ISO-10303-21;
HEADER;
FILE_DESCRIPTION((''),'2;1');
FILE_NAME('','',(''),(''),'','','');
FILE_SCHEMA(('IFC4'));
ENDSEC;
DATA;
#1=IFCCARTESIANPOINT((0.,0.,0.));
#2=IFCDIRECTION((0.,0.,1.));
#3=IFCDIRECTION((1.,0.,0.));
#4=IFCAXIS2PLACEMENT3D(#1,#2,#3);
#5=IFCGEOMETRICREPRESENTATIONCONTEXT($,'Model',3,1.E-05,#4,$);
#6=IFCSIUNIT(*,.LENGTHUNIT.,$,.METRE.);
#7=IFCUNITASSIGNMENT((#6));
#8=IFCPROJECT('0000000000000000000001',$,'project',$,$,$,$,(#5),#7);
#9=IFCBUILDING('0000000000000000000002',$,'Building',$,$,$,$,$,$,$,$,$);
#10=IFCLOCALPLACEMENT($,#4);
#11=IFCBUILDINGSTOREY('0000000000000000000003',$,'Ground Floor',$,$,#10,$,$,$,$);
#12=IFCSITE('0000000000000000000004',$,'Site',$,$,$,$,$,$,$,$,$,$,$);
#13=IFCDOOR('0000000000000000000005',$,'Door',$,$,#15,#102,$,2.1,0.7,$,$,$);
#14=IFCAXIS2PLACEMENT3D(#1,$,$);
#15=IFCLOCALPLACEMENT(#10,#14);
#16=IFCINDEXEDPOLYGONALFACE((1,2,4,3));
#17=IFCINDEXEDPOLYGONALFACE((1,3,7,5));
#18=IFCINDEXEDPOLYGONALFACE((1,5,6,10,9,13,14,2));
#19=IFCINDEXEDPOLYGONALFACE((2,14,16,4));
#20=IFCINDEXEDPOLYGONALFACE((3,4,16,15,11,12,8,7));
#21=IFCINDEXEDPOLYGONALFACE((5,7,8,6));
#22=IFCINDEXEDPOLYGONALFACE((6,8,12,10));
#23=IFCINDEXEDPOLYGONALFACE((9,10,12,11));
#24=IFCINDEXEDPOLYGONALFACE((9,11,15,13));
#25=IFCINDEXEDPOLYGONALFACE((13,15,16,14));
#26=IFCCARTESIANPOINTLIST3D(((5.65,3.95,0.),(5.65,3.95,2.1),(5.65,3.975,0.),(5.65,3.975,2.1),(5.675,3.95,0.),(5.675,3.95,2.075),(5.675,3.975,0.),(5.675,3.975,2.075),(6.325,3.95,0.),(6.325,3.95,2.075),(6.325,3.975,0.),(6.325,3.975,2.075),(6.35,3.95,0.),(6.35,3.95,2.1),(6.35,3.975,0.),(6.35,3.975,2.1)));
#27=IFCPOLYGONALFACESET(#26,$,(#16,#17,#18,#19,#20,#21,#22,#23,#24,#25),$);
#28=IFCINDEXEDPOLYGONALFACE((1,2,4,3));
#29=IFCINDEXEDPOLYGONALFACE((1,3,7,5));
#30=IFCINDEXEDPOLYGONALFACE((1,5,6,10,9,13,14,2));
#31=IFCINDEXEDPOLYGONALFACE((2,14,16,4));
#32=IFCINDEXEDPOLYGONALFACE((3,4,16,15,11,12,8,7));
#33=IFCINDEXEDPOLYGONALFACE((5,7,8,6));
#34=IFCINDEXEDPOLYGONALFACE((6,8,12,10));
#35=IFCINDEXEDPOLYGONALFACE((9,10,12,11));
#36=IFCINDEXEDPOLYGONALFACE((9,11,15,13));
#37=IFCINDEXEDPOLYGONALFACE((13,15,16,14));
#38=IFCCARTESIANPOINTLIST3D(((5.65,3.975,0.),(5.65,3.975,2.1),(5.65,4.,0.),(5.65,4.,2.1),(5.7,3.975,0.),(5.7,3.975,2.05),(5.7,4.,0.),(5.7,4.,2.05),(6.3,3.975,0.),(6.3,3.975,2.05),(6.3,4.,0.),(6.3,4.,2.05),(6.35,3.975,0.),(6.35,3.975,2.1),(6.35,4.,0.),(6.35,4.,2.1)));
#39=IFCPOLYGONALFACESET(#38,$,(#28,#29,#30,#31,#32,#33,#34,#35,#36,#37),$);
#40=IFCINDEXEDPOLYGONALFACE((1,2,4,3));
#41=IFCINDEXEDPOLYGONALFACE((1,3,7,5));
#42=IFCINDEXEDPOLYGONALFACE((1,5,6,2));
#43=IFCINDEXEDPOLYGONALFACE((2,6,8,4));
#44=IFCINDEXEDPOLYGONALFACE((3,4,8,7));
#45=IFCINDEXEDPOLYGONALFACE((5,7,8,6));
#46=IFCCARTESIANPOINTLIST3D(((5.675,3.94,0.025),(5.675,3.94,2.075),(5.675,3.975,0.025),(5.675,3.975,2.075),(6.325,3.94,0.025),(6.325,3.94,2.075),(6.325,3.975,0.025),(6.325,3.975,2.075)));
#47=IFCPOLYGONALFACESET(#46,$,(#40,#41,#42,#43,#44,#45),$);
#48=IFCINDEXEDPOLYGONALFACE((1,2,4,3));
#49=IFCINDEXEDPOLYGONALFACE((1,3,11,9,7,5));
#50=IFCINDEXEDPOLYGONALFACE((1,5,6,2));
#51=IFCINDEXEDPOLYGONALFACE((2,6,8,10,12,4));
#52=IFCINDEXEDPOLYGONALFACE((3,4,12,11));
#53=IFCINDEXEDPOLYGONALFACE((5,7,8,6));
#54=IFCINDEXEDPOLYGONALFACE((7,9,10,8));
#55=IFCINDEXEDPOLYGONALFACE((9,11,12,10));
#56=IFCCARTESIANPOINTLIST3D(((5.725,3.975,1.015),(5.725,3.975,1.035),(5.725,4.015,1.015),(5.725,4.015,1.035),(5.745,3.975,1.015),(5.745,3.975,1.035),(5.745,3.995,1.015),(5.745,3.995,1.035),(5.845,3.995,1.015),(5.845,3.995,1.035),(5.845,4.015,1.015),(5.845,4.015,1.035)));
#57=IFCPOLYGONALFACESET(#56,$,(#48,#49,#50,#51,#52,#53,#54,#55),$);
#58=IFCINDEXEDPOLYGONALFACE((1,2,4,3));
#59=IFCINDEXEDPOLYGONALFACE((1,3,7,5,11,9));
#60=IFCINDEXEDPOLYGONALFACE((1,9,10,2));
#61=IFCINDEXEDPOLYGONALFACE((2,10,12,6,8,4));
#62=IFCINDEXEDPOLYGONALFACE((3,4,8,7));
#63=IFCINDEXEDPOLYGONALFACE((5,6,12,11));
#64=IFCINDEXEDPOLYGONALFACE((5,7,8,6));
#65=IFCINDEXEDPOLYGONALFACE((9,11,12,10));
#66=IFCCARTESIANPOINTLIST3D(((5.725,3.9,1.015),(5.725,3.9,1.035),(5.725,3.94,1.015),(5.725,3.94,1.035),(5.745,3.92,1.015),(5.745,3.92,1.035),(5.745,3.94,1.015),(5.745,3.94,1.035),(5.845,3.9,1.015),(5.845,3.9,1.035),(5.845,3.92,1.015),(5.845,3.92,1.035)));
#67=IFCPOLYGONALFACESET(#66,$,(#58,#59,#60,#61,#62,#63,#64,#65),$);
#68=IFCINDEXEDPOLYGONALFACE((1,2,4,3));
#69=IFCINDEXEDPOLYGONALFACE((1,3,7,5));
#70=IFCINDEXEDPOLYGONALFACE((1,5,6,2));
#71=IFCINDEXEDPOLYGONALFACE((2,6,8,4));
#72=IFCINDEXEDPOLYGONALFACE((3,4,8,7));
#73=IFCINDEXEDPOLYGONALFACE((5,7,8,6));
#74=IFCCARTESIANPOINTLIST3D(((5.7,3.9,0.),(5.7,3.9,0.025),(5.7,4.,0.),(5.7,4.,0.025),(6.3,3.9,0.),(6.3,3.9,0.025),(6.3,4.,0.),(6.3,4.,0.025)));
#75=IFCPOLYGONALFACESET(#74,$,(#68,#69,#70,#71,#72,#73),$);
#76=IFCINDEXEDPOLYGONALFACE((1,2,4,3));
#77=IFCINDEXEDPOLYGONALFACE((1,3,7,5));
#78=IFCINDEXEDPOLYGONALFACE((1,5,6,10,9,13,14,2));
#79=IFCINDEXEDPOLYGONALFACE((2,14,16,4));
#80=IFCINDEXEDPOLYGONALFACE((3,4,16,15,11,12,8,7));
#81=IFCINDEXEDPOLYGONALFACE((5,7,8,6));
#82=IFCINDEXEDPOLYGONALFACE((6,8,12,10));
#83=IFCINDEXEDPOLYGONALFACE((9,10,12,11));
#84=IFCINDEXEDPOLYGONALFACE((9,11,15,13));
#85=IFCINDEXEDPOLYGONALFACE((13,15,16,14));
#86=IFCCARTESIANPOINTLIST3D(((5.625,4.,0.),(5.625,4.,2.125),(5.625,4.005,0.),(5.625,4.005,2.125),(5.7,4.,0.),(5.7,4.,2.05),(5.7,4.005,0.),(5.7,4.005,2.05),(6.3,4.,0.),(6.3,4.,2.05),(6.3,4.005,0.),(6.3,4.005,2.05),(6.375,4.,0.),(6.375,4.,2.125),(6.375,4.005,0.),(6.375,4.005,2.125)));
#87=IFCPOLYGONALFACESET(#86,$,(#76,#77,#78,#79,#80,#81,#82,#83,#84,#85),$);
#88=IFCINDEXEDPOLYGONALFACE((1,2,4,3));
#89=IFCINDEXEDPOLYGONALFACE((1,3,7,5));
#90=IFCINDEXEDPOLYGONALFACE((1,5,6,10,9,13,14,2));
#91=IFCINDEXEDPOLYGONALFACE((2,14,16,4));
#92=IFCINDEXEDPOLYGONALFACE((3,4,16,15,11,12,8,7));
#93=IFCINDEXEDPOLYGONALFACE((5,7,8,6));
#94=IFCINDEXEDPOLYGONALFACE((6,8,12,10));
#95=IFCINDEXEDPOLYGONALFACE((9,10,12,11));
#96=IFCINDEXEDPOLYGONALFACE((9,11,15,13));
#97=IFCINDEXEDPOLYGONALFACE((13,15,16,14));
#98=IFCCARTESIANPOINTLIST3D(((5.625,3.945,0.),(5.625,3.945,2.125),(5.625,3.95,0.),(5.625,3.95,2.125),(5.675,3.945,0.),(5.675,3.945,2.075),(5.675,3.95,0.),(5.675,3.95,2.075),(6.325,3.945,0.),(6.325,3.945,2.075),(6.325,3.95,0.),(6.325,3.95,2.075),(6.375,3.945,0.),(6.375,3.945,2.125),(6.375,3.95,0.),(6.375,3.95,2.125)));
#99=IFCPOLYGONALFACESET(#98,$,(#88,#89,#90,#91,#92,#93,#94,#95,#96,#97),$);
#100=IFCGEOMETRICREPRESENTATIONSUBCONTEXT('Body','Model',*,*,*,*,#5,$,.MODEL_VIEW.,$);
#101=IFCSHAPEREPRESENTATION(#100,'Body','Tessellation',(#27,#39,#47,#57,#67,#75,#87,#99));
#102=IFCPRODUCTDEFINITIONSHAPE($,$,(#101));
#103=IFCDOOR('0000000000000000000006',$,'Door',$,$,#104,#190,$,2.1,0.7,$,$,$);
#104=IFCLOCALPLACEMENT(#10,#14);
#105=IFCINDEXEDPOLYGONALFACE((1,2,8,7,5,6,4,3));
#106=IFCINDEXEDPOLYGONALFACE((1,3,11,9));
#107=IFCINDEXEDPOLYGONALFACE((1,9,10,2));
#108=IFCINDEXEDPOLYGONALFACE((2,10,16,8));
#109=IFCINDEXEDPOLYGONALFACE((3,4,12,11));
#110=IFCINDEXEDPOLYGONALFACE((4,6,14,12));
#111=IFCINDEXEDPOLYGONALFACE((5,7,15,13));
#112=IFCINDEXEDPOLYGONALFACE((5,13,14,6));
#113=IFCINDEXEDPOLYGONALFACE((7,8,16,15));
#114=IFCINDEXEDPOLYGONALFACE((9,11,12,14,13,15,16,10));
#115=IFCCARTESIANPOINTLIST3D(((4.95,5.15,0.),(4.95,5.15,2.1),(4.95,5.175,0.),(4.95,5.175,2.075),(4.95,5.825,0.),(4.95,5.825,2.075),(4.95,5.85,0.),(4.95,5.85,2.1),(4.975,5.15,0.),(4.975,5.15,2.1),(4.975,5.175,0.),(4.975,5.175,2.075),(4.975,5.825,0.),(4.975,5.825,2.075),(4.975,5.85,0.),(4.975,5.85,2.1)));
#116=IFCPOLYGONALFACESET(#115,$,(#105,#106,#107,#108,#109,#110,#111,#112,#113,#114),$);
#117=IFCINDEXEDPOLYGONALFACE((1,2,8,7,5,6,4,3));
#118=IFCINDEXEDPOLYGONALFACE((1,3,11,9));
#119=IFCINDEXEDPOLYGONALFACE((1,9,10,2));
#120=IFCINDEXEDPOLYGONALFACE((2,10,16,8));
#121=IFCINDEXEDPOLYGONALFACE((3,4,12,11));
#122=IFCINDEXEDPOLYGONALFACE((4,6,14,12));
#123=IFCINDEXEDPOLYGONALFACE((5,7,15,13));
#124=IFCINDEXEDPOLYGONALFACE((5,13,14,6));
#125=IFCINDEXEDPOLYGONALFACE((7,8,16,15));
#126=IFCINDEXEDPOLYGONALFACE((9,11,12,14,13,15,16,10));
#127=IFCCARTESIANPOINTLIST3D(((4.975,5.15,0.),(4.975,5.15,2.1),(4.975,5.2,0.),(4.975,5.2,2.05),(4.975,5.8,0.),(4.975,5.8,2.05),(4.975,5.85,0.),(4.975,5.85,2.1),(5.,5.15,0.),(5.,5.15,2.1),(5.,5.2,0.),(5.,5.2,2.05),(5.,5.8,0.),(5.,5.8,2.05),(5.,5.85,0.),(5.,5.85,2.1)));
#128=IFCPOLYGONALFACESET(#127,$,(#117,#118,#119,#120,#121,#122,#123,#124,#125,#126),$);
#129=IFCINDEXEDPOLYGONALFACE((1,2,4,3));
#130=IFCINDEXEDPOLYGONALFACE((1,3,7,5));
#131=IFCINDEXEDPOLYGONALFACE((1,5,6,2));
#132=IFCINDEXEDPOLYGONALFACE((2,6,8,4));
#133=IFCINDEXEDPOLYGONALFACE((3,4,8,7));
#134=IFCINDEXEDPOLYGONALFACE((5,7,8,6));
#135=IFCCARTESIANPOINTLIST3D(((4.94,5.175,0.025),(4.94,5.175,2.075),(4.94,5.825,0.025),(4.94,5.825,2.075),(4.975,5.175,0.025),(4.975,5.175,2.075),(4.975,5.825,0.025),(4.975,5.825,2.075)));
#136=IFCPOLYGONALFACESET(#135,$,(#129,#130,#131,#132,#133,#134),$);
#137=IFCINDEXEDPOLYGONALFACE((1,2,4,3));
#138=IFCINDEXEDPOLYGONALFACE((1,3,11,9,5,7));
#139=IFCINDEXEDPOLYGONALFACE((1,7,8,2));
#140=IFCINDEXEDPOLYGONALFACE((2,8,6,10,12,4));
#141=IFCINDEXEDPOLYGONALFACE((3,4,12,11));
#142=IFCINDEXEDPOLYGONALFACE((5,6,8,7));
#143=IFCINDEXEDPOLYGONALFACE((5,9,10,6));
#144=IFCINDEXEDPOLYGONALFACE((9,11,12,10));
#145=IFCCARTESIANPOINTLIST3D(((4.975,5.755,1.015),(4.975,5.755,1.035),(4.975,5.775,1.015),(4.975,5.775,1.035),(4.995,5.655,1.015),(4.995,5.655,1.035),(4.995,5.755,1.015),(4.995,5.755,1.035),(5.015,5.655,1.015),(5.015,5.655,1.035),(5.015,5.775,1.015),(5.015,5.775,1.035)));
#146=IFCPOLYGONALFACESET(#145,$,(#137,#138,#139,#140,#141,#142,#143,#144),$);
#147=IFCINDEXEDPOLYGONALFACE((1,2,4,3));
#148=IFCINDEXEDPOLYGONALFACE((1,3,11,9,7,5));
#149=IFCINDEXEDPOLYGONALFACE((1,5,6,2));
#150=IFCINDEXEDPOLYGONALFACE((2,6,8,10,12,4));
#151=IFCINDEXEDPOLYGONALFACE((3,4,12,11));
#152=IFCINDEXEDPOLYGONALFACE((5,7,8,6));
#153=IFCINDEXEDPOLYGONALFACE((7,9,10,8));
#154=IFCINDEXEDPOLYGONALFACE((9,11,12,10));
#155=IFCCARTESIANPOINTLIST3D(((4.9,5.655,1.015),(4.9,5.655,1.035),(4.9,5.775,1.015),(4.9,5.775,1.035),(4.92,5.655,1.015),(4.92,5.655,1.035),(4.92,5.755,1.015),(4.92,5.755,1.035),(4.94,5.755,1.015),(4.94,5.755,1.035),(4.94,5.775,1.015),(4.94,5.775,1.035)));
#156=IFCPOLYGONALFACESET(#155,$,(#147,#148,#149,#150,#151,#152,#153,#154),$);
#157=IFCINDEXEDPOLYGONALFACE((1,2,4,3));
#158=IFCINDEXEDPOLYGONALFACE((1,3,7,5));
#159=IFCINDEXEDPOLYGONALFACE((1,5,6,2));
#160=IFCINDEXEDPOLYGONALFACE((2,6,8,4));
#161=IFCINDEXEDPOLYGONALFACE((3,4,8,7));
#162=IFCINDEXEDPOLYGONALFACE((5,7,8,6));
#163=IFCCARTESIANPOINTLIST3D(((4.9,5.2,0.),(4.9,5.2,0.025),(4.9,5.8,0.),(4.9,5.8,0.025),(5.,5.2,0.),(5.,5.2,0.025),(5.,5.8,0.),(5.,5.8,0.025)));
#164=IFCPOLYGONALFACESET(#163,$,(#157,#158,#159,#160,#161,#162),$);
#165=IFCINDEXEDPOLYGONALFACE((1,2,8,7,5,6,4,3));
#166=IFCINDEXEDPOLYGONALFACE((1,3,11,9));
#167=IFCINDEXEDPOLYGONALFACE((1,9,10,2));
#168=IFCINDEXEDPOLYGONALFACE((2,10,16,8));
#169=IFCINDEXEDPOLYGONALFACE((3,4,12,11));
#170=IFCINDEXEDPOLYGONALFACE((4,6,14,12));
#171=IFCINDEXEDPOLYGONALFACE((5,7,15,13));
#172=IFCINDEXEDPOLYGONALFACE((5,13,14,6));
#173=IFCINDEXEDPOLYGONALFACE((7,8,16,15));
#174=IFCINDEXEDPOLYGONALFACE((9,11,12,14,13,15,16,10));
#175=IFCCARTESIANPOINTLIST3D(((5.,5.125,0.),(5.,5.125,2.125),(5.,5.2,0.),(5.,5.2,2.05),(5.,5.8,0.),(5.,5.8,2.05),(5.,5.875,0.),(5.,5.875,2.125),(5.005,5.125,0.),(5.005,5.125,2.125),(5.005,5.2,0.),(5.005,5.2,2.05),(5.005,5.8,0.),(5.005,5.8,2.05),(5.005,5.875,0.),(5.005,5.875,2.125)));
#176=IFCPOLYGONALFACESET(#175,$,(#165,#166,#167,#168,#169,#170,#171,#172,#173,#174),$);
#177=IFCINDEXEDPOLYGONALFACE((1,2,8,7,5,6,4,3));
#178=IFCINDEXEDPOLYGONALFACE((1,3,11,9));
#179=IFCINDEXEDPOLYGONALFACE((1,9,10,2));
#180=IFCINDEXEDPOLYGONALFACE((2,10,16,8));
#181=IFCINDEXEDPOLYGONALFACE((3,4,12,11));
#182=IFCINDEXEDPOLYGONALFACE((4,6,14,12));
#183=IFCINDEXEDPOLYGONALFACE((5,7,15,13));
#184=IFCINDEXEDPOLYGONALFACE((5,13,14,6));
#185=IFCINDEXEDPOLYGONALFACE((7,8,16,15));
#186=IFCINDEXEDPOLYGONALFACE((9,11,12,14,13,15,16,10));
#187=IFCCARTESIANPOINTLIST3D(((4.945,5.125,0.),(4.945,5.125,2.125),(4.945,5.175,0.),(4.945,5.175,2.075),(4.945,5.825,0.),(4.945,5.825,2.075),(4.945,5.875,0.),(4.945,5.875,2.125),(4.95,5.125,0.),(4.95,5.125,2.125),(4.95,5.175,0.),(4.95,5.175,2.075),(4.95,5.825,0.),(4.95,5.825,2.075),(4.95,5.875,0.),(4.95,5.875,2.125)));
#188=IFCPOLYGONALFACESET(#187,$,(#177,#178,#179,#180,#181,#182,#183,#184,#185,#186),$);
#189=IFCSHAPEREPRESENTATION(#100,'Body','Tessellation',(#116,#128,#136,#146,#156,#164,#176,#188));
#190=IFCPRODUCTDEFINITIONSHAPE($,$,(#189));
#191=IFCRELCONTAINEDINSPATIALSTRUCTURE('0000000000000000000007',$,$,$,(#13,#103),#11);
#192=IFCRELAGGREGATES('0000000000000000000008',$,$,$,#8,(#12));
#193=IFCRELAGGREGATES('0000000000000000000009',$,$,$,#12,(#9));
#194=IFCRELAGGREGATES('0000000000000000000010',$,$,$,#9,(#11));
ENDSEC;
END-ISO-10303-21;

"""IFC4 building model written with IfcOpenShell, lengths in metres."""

from ifc_helpers import new_model, si_unit, frame, origin_with_axes, place, context, subcontext, project, spatial, line, indexed_curve, outline, extrude, element, save


model = new_model("IFC4")

# Units and contexts
model_context = context("Model", 3, precision=1e-05, world=origin_with_axes())
body_context = subcontext(model_context, "Body", "Model", "MODEL_VIEW")
ifc_project = project(units=[si_unit("LENGTHUNIT", "METRE")], contexts=[model_context])

# Site, building, storey
site = spatial("IfcSite", under=ifc_project, Name="Site")
building = spatial("IfcBuilding", under=site, Name="Building")
storey_placement = place(None, origin_with_axes())
storey = spatial("IfcBuildingStorey", under=building, at=storey_placement, Name="Ground Floor")

# Doors
door_1_placement = place(storey_placement, frame((6.35, 4.0, 0.0), z_axis=(0.0, 0.0, 1.0), x_axis=(-1.0, 0.0, 0.0)))
element("IfcDoor", 1, at=door_1_placement, inside=storey, Name="Door", OverallHeight=2.1, OverallWidth=0.7, context=body_context, shape_type="SweptSolid", body=[
    extrude(outline(indexed_curve([(0.0, 0.0), (0.0, 2.1), (0.7, 2.1), (0.7, 0.0), (0.675, 0.0), (0.675, 2.075), (0.025, 2.075), (0.025, 0.0)], segments=[line(1, 2, 3, 4, 5, 6, 7, 8, 1)])), frame((0.0, 0.025, 0.0), z_axis=(0.0, -1.0, 0.0), x_axis=(1.0, 0.0, 0.0)), (0.0, 0.0, -1.0), 0.025),
    extrude(outline(indexed_curve([(0.0, 0.0), (0.0, 2.1), (0.7, 2.1), (0.7, 0.0), (0.65, 0.0), (0.65, 2.05), (0.05, 2.05), (0.05, 0.0)], segments=[line(1, 2, 3, 4, 5, 6, 7, 8, 1)])), frame((0.0, 0.0, 0.0), z_axis=(0.0, -1.0, 0.0), x_axis=(1.0, 0.0, 0.0)), (0.0, 0.0, -1.0), 0.025),
    extrude(outline(indexed_curve([(0.0, 0.0), (0.65, 0.0), (0.65, 0.035), (0.0, 0.035)], segments=[line(1, 2, 3, 4, 1)])), frame((0.025, 0.025, 0.025), z_axis=(0.0, 0.0, 1.0), x_axis=(1.0, 0.0, 0.0)), (0.0, 0.0, 1.0), 2.05),
    extrude(outline(indexed_curve([(0.0, 0.0), (0.0, -0.04), (-0.12, -0.04), (-0.12, -0.02), (-0.02, -0.02), (-0.02, 0.0)], segments=[line(1, 2, 3, 4, 5, 6, 1)])), frame((0.625, 0.025, 1.015), z_axis=(0.0, 0.0, 1.0), x_axis=(1.0, 0.0, 0.0)), (0.0, 0.0, 1.0), 0.02),
    extrude(outline(indexed_curve([(0.0, 0.0), (0.0, 0.04), (-0.12, 0.04), (-0.12, 0.02), (-0.02, 0.02), (-0.02, 0.0)], segments=[line(1, 2, 3, 4, 5, 6, 1)])), frame((0.625, 0.06, 1.015), z_axis=(0.0, 0.0, 1.0), x_axis=(1.0, 0.0, 0.0)), (0.0, 0.0, 1.0), 0.02),
    extrude(outline(indexed_curve([(0.0, 0.0), (0.6, 0.0), (0.6, 0.1), (0.0, 0.1)], segments=[line(1, 2, 3, 4, 1)])), frame((0.05, 0.0, 0.0), z_axis=(0.0, 0.0, 1.0), x_axis=(1.0, 0.0, 0.0)), (0.0, 0.0, 1.0), 0.025),
    extrude(outline(indexed_curve([(0.0, 0.0), (0.0, 2.125), (0.75, 2.125), (0.75, 0.0), (0.675, 0.0), (0.675, 2.05), (0.075, 2.05), (0.075, 0.0)], segments=[line(1, 2, 3, 4, 5, 6, 7, 8, 1)])), frame((-0.025, -0.005, 0.0), z_axis=(0.0, -1.0, 0.0), x_axis=(1.0, 0.0, 0.0)), (0.0, 0.0, -1.0), 0.005),
    extrude(outline(indexed_curve([(0.0, 0.0), (0.0, 2.125), (0.75, 2.125), (0.75, 0.0), (0.7, 0.0), (0.7, 2.075), (0.05, 2.075), (0.05, 0.0)], segments=[line(1, 2, 3, 4, 5, 6, 7, 8, 1)])), frame((-0.025, 0.05, 0.0), z_axis=(0.0, -1.0, 0.0), x_axis=(1.0, 0.0, 0.0)), (0.0, 0.0, -1.0), 0.005),
])
door_2_placement = place(storey_placement, frame((5.0, 5.15, 0.0), z_axis=(0.0, 0.0, 1.0), x_axis=(0.0, 1.0, 0.0)))
element("IfcDoor", 2, at=door_2_placement, inside=storey, Name="Door", OverallHeight=2.1, OverallWidth=0.7, context=body_context, shape_type="SweptSolid", body=[
    extrude(outline(indexed_curve([(0.0, 0.0), (0.0, 2.1), (0.7, 2.1), (0.7, 0.0), (0.675, 0.0), (0.675, 2.075), (0.025, 2.075), (0.025, 0.0)], segments=[line(1, 2, 3, 4, 5, 6, 7, 8, 1)])), frame((0.0, 0.025, 0.0), z_axis=(0.0, -1.0, 0.0), x_axis=(1.0, 0.0, 0.0)), (0.0, 0.0, -1.0), 0.025),
    extrude(outline(indexed_curve([(0.0, 0.0), (0.0, 2.1), (0.7, 2.1), (0.7, 0.0), (0.65, 0.0), (0.65, 2.05), (0.05, 2.05), (0.05, 0.0)], segments=[line(1, 2, 3, 4, 5, 6, 7, 8, 1)])), frame((0.0, 0.0, 0.0), z_axis=(0.0, -1.0, 0.0), x_axis=(1.0, 0.0, 0.0)), (0.0, 0.0, -1.0), 0.025),
    extrude(outline(indexed_curve([(0.0, 0.0), (0.65, 0.0), (0.65, 0.035), (0.0, 0.035)], segments=[line(1, 2, 3, 4, 1)])), frame((0.025, 0.025, 0.025), z_axis=(0.0, 0.0, 1.0), x_axis=(1.0, 0.0, 0.0)), (0.0, 0.0, 1.0), 2.05),
    extrude(outline(indexed_curve([(0.0, 0.0), (0.0, -0.04), (-0.12, -0.04), (-0.12, -0.02), (-0.02, -0.02), (-0.02, 0.0)], segments=[line(1, 2, 3, 4, 5, 6, 1)])), frame((0.625, 0.025, 1.015), z_axis=(0.0, 0.0, 1.0), x_axis=(1.0, 0.0, 0.0)), (0.0, 0.0, 1.0), 0.02),
    extrude(outline(indexed_curve([(0.0, 0.0), (0.0, 0.04), (-0.12, 0.04), (-0.12, 0.02), (-0.02, 0.02), (-0.02, 0.0)], segments=[line(1, 2, 3, 4, 5, 6, 1)])), frame((0.625, 0.06, 1.015), z_axis=(0.0, 0.0, 1.0), x_axis=(1.0, 0.0, 0.0)), (0.0, 0.0, 1.0), 0.02),
    extrude(outline(indexed_curve([(0.0, 0.0), (0.6, 0.0), (0.6, 0.1), (0.0, 0.1)], segments=[line(1, 2, 3, 4, 1)])), frame((0.05, 0.0, 0.0), z_axis=(0.0, 0.0, 1.0), x_axis=(1.0, 0.0, 0.0)), (0.0, 0.0, 1.0), 0.025),
    extrude(outline(indexed_curve([(0.0, 0.0), (0.0, 2.125), (0.75, 2.125), (0.75, 0.0), (0.675, 0.0), (0.675, 2.05), (0.075, 2.05), (0.075, 0.0)], segments=[line(1, 2, 3, 4, 5, 6, 7, 8, 1)])), frame((-0.025, -0.005, 0.0), z_axis=(0.0, -1.0, 0.0), x_axis=(1.0, 0.0, 0.0)), (0.0, 0.0, -1.0), 0.005),
    extrude(outline(indexed_curve([(0.0, 0.0), (0.0, 2.125), (0.75, 2.125), (0.75, 0.0), (0.7, 0.0), (0.7, 2.075), (0.05, 2.075), (0.05, 0.0)], segments=[line(1, 2, 3, 4, 5, 6, 7, 8, 1)])), frame((-0.025, 0.05, 0.0), z_axis=(0.0, -1.0, 0.0), x_axis=(1.0, 0.0, 0.0)), (0.0, 0.0, -1.0), 0.005),
])

save(model, "model.ifc")
